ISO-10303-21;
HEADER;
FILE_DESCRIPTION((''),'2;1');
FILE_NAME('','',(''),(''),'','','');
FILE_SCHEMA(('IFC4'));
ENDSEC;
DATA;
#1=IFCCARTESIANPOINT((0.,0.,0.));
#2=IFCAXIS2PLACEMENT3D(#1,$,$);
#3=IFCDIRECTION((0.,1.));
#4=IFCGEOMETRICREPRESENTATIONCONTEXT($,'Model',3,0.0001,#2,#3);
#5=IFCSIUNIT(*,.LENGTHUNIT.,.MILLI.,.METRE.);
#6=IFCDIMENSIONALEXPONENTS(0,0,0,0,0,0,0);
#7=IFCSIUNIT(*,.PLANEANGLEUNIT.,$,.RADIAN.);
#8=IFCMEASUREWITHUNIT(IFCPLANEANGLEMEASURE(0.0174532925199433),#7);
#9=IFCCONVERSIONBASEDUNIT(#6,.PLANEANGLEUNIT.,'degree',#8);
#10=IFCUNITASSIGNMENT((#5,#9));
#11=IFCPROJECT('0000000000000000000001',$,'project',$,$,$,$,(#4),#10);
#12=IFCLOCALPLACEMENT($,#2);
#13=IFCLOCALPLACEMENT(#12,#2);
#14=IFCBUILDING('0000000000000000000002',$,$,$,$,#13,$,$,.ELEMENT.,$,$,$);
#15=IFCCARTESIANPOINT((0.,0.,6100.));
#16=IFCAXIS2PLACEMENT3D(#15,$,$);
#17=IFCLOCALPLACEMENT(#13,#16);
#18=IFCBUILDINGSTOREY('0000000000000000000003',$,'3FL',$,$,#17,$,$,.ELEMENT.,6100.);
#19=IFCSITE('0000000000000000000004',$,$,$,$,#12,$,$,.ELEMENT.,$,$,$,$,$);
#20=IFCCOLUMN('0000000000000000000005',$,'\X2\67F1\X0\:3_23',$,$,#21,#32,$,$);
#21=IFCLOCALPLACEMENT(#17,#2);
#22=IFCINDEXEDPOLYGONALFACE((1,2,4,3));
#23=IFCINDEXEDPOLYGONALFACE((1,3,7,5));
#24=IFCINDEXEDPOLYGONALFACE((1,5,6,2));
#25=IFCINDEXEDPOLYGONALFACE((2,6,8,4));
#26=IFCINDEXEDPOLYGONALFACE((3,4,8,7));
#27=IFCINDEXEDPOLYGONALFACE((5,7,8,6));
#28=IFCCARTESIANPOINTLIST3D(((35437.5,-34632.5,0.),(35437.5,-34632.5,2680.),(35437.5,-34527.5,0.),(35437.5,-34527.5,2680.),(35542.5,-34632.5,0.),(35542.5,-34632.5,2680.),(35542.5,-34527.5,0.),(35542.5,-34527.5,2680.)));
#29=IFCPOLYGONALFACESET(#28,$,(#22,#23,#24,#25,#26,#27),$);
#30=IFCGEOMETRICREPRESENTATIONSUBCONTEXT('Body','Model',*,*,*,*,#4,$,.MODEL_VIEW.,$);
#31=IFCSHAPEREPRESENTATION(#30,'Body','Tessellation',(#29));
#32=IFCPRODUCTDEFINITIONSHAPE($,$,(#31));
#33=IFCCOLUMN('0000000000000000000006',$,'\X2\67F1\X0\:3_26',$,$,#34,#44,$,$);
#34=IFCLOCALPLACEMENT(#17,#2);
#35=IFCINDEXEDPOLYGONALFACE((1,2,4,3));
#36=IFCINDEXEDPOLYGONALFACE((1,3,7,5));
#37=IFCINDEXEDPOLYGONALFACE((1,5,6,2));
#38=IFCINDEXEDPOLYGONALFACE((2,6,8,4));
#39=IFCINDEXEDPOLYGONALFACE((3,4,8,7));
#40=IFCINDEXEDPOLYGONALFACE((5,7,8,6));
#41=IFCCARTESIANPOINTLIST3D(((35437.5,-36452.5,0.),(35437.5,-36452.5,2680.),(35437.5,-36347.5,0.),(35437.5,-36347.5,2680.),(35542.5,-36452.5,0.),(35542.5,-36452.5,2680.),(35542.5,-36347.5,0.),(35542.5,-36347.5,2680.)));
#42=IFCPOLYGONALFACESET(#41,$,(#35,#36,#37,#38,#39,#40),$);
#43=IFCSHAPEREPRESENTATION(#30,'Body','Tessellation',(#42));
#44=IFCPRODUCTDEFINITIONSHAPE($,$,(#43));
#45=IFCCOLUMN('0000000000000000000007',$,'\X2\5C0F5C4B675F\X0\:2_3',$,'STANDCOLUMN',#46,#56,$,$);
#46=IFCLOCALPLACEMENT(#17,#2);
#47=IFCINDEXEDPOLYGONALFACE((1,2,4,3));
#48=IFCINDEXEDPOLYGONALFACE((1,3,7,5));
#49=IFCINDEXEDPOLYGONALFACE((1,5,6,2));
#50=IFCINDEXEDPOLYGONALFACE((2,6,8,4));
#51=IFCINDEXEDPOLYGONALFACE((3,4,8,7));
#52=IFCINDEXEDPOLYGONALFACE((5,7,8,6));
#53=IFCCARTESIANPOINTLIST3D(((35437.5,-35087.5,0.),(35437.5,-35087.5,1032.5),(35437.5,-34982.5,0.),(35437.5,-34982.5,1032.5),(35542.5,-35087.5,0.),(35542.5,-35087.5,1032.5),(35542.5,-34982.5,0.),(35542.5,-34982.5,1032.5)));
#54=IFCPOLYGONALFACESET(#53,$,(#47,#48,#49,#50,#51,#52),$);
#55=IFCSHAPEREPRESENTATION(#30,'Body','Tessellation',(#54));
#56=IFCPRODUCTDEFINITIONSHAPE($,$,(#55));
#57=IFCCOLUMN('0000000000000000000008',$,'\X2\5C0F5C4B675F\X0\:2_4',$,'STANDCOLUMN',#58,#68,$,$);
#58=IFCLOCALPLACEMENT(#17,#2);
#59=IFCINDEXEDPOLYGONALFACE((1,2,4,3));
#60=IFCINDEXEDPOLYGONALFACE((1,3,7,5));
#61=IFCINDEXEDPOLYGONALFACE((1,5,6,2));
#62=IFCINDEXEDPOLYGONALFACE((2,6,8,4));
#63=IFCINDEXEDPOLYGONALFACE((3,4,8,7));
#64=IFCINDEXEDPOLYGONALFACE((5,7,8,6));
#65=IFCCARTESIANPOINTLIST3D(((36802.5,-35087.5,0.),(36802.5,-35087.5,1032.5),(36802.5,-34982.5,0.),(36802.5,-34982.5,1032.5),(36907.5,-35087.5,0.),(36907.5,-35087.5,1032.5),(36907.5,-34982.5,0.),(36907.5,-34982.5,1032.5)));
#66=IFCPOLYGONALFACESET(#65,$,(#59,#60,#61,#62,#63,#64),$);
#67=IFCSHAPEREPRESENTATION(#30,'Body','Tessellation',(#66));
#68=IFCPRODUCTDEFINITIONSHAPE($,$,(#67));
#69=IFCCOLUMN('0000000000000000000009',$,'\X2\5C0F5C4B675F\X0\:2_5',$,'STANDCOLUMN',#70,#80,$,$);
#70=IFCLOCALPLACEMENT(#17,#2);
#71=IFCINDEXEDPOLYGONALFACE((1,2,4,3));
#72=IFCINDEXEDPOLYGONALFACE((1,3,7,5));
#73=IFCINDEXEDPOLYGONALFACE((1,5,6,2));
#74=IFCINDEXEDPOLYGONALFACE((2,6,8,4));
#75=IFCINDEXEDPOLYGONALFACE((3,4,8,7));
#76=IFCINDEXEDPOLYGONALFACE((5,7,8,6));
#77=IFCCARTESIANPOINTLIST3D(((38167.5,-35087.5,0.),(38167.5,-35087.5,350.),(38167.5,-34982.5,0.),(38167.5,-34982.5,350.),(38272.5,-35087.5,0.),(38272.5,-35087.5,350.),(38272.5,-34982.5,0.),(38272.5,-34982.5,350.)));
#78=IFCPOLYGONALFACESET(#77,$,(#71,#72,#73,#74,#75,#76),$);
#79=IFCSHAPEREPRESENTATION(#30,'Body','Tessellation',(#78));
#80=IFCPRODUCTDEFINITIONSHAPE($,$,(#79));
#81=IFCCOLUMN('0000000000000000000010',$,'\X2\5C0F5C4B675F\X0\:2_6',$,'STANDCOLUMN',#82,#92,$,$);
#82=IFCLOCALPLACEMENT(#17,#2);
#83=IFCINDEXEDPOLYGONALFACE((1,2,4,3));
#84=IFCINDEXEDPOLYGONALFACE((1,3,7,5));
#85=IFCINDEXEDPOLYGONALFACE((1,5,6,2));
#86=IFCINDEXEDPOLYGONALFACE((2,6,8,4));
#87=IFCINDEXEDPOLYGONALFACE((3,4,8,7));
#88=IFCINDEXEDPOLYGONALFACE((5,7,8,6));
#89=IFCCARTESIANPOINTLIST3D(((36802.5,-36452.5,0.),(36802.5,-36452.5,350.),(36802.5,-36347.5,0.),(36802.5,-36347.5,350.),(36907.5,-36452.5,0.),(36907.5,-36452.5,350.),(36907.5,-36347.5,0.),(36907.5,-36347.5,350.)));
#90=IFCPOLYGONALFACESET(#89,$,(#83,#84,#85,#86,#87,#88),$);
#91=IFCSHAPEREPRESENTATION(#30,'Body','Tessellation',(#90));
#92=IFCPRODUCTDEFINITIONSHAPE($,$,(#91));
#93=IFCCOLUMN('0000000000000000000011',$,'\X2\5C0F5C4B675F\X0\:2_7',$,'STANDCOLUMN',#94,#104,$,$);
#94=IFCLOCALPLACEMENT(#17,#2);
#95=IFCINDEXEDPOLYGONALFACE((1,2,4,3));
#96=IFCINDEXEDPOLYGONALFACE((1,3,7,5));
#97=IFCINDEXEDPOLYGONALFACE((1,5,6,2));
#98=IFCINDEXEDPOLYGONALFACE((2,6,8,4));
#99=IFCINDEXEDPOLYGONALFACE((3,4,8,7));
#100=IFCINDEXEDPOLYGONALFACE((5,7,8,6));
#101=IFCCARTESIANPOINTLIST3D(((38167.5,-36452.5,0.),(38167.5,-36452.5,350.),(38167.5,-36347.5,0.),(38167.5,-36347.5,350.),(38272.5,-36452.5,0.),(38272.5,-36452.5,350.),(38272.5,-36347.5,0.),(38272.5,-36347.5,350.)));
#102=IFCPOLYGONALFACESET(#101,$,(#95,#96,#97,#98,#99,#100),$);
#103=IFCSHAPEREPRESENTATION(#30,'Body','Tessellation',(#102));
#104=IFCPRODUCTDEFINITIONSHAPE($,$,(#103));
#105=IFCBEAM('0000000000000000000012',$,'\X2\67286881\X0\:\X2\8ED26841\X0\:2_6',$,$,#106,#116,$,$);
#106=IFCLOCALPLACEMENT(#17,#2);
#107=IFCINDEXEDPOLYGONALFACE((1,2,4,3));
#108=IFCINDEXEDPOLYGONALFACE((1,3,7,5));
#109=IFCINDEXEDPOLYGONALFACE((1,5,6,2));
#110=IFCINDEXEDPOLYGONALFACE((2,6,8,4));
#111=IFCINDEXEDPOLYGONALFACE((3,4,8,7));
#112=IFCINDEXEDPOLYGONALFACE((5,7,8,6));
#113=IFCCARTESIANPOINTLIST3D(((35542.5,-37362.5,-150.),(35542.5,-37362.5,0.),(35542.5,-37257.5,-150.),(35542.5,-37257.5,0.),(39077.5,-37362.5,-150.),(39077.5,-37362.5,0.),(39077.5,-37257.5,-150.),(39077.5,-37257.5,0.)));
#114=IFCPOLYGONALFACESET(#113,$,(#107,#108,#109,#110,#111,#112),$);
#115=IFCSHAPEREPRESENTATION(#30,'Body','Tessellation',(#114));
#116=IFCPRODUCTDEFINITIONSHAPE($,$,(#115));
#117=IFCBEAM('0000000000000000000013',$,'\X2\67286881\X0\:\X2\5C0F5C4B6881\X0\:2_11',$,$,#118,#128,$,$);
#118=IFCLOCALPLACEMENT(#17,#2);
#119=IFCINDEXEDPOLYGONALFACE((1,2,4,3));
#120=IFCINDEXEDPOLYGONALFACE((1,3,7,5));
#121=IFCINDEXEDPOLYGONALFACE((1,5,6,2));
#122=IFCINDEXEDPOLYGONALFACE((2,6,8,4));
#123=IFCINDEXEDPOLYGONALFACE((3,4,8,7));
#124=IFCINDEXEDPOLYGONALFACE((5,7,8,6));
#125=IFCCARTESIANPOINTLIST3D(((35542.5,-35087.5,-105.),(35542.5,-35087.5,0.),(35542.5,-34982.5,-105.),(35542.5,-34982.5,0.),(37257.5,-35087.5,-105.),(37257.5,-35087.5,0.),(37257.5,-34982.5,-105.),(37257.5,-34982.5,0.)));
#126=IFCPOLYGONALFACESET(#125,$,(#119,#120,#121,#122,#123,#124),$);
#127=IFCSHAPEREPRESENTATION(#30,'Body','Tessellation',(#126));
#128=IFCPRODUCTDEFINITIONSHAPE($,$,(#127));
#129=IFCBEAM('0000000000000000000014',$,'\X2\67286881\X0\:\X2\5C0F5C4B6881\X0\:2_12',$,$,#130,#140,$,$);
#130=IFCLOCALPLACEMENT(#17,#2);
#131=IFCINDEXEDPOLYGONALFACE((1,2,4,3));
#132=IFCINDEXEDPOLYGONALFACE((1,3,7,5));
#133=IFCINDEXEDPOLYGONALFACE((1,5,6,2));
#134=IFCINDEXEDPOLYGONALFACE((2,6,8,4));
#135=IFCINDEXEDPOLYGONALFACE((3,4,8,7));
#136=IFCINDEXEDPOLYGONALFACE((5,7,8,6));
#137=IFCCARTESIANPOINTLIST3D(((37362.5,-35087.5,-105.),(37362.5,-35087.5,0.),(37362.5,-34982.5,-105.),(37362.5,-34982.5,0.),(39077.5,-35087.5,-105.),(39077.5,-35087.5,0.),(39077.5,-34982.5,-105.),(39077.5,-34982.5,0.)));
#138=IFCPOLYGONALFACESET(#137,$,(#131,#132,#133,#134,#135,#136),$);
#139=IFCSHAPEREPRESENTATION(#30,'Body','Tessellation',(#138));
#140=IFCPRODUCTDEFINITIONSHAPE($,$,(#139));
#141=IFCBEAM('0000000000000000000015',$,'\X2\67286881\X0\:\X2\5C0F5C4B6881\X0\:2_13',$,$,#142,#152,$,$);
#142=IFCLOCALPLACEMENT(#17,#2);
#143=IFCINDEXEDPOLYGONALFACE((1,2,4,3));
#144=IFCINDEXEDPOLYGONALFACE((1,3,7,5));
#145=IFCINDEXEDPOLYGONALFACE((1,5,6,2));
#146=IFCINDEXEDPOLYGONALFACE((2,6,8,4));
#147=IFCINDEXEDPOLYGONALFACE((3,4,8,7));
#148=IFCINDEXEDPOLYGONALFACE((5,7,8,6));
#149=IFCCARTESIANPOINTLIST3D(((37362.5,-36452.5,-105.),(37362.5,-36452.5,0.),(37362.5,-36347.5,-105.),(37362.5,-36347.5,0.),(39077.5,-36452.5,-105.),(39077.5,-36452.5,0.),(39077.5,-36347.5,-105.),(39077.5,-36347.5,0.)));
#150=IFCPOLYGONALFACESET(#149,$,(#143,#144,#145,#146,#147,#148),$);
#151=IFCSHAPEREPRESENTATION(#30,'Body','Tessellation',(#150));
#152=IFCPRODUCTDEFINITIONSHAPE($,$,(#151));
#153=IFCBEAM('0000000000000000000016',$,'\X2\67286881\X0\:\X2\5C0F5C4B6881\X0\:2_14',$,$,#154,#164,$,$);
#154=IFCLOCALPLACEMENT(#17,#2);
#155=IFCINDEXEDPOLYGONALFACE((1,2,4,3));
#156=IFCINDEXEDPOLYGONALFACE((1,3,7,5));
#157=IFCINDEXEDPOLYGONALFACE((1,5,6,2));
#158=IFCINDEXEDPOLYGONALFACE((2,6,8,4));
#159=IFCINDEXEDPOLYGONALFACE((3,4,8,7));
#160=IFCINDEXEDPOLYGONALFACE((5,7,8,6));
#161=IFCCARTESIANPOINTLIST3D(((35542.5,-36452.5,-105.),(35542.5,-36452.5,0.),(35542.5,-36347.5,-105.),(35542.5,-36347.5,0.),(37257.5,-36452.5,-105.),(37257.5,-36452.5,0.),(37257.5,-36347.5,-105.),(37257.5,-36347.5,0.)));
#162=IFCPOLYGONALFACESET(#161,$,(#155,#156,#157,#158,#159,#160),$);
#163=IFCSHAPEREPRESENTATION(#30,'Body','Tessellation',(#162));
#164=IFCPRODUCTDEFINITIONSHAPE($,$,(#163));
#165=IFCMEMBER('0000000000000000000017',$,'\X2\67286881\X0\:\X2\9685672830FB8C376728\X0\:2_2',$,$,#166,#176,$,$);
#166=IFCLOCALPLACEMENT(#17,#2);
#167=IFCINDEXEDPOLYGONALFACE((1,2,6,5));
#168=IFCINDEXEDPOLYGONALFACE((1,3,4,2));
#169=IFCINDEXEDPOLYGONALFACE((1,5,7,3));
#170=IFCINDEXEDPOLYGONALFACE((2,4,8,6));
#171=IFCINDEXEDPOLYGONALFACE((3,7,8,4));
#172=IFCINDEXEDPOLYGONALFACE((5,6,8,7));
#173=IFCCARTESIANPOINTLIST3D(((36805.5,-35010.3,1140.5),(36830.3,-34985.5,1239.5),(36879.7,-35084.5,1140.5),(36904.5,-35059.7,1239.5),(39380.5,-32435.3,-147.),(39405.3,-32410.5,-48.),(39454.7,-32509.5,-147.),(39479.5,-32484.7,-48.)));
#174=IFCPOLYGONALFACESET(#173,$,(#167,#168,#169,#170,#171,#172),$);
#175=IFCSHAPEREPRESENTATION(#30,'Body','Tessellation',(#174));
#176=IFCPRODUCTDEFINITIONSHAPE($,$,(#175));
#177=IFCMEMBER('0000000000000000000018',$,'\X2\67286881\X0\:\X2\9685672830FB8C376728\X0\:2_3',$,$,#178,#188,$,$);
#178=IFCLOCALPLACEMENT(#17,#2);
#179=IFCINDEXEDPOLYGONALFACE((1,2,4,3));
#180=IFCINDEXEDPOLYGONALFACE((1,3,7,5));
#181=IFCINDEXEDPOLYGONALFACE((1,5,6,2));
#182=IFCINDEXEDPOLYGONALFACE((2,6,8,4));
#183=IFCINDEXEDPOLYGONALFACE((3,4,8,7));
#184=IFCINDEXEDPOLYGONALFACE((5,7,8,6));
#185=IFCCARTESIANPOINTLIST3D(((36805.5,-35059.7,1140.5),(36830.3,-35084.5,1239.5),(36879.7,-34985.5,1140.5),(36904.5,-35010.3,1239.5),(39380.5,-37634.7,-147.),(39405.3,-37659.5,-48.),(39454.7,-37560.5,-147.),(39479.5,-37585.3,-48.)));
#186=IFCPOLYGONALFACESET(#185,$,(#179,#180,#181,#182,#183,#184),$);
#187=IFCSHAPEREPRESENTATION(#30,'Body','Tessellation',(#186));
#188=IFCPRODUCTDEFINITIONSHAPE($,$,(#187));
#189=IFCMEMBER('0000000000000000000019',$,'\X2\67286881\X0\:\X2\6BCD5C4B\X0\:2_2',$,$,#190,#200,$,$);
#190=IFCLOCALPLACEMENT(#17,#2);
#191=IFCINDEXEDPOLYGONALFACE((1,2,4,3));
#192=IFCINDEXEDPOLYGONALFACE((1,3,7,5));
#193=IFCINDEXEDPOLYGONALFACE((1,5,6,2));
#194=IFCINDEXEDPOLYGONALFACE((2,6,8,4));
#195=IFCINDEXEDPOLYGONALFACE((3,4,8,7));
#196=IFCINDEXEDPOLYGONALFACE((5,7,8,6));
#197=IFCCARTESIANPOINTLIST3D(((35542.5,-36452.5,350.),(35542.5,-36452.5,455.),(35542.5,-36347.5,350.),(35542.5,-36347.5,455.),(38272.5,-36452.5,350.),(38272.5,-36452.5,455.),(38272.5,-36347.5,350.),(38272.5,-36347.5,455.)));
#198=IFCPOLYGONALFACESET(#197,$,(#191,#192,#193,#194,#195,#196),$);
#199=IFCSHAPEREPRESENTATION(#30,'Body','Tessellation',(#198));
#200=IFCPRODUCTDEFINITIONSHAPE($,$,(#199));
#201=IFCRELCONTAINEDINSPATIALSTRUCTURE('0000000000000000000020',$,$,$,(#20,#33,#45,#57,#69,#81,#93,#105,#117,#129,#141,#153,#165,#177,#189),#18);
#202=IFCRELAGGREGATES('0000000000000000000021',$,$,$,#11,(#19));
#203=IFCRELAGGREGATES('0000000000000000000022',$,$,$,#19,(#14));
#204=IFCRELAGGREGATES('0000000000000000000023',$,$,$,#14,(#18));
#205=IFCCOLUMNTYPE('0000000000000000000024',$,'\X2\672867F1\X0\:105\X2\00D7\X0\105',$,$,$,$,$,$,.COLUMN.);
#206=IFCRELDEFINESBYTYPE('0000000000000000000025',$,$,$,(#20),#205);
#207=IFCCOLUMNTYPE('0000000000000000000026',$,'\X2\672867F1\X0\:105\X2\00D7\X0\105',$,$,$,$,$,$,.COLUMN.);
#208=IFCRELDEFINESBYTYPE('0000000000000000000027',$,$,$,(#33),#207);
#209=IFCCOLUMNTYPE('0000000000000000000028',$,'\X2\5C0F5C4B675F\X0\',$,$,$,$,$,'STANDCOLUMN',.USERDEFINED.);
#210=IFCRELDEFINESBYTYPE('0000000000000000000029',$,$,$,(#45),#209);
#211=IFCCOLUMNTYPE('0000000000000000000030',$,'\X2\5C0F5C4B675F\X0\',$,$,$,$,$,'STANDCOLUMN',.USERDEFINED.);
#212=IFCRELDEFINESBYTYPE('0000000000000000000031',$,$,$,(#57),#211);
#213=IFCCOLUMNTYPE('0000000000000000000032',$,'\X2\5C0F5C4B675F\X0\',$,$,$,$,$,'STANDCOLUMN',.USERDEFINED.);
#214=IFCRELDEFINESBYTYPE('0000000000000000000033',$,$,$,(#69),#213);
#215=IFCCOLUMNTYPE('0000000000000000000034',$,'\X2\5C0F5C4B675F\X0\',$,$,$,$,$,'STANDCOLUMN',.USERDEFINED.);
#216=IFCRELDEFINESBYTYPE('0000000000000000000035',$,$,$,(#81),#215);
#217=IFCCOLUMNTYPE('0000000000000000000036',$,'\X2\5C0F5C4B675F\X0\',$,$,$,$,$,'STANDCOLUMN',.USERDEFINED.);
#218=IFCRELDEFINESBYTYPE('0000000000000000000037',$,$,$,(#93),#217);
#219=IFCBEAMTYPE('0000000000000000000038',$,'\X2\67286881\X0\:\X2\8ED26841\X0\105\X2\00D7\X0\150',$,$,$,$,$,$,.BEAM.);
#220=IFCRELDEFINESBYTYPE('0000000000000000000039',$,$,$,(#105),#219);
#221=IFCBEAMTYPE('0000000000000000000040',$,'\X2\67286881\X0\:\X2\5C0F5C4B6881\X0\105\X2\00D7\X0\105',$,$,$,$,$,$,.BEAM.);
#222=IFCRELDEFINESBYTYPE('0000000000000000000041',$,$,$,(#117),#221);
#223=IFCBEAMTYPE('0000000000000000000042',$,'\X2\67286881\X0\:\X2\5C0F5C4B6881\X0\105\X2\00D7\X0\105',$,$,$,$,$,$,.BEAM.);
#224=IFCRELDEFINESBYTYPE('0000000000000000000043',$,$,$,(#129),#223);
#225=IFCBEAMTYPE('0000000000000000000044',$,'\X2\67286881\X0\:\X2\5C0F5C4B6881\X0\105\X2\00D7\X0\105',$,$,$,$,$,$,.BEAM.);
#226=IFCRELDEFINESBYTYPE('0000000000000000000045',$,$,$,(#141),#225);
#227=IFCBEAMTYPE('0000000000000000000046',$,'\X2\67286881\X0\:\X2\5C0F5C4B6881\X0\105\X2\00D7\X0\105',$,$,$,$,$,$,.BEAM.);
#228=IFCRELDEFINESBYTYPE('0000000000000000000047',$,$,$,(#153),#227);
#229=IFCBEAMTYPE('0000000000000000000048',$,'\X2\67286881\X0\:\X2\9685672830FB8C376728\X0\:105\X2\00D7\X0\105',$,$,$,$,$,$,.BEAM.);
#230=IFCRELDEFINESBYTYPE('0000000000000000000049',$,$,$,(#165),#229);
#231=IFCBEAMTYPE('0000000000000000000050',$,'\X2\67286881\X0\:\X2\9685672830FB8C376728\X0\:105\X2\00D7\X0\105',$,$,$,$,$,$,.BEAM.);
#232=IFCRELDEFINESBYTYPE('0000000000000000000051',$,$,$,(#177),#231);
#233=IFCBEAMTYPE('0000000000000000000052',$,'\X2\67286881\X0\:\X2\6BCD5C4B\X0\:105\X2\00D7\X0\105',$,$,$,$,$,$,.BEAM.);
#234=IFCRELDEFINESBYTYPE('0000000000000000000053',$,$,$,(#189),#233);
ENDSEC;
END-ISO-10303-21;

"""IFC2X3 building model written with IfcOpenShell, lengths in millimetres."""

from ifc_helpers import new_model, entity, si_unit, converted_unit, direction, frame, origin, origin_with_axes, origin_2d, place, context, subcontext, project, spatial, rectangle, extrude, type_object, element, save


model = new_model("IFC2X3")

# Units and contexts
model_context = context("Model", 3, precision=0.0001, world=origin(), true_north=direction((0.0, 1.0)))
body_context = subcontext(model_context, "Body", "Model", "MODEL_VIEW")
ifc_project = project(units=[si_unit("LENGTHUNIT", "METRE", prefix="MILLI"), converted_unit("PLANEANGLEUNIT", "degree", entity("IfcPlaneAngleMeasure", 0.0174532925199433), si_unit("PLANEANGLEUNIT", "RADIAN"), dimensions=[0, 0, 0, 0, 0, 0, 0])], contexts=[model_context])

# Site, building, storey
site_placement = place(None, origin())
site = spatial("IfcSite", under=ifc_project, at=site_placement, CompositionType="ELEMENT")
building_placement = place(site_placement, origin())
building = spatial("IfcBuilding", under=site, at=building_placement, CompositionType="ELEMENT")
storey_placement = place(building_placement, frame((0.0, 0.0, 6100.0)))
storey = spatial("IfcBuildingStorey", under=building, at=storey_placement, Name="3FL", CompositionType="ELEMENT", Elevation=6100.0)

# Columns
column_type_1 = type_object("IfcColumnType", Name="木柱:105×105", PredefinedType="COLUMN")
column_1_placement = place(storey_placement, frame((35490.0, -34580.0, 0.0)))
element("IfcColumn", 1, at=column_1_placement, inside=storey, type_object=column_type_1, Name="柱:3_23", context=body_context, shape_type="SweptSolid", body=[
    extrude(rectangle(XDim=105.0, YDim=105.0, at=origin_2d()), origin_with_axes(), (0.0, 0.0, 1.0), 2680.0),
])
column_type_2 = type_object("IfcColumnType", Name="木柱:105×105", PredefinedType="COLUMN")
column_2_placement = place(storey_placement, frame((35490.0, -36400.0, 0.0)))
element("IfcColumn", 2, at=column_2_placement, inside=storey, type_object=column_type_2, Name="柱:3_26", context=body_context, shape_type="SweptSolid", body=[
    extrude(rectangle(XDim=105.0, YDim=105.0, at=origin_2d()), origin_with_axes(), (0.0, 0.0, 1.0), 2680.0),
])
column_type_3 = type_object("IfcColumnType", Name="小屋束", ElementType="STANDCOLUMN", PredefinedType="USERDEFINED")
column_3_placement = place(storey_placement, frame((35490.0, -35035.0, 0.0)))
element("IfcColumn", 3, at=column_3_placement, inside=storey, type_object=column_type_3, Name="小屋束:2_3", ObjectType="STANDCOLUMN", context=body_context, shape_type="SweptSolid", body=[
    extrude(rectangle(XDim=105.0, YDim=105.0, at=origin_2d()), origin_with_axes(), (0.0, 0.0, 1.0), 1032.5),
])
column_type_4 = type_object("IfcColumnType", Name="小屋束", ElementType="STANDCOLUMN", PredefinedType="USERDEFINED")
column_4_placement = place(storey_placement, frame((36855.0, -35035.0, 0.0)))
element("IfcColumn", 4, at=column_4_placement, inside=storey, type_object=column_type_4, Name="小屋束:2_4", ObjectType="STANDCOLUMN", context=body_context, shape_type="SweptSolid", body=[
    extrude(rectangle(XDim=105.0, YDim=105.0, at=origin_2d()), origin_with_axes(), (0.0, 0.0, 1.0), 1032.5),
])
column_type_5 = type_object("IfcColumnType", Name="小屋束", ElementType="STANDCOLUMN", PredefinedType="USERDEFINED")
column_5_placement = place(storey_placement, frame((38220.0, -35035.0, 0.0)))
element("IfcColumn", 5, at=column_5_placement, inside=storey, type_object=column_type_5, Name="小屋束:2_5", ObjectType="STANDCOLUMN", context=body_context, shape_type="SweptSolid", body=[
    extrude(rectangle(XDim=105.0, YDim=105.0, at=origin_2d()), origin_with_axes(), (0.0, 0.0, 1.0), 350.0),
])
column_type_6 = type_object("IfcColumnType", Name="小屋束", ElementType="STANDCOLUMN", PredefinedType="USERDEFINED")
column_6_placement = place(storey_placement, frame((36855.0, -36400.0, 0.0)))
element("IfcColumn", 6, at=column_6_placement, inside=storey, type_object=column_type_6, Name="小屋束:2_6", ObjectType="STANDCOLUMN", context=body_context, shape_type="SweptSolid", body=[
    extrude(rectangle(XDim=105.0, YDim=105.0, at=origin_2d()), origin_with_axes(), (0.0, 0.0, 1.0), 350.0),
])
column_type_7 = type_object("IfcColumnType", Name="小屋束", ElementType="STANDCOLUMN", PredefinedType="USERDEFINED")
column_7_placement = place(storey_placement, frame((38220.0, -36400.0, 0.0)))
element("IfcColumn", 7, at=column_7_placement, inside=storey, type_object=column_type_7, Name="小屋束:2_7", ObjectType="STANDCOLUMN", context=body_context, shape_type="SweptSolid", body=[
    extrude(rectangle(XDim=105.0, YDim=105.0, at=origin_2d()), origin_with_axes(), (0.0, 0.0, 1.0), 350.0),
])

# Beams
beam_type_1 = type_object("IfcBeamType", Name="木梁:軒桁105×150", PredefinedType="BEAM")
beam_1_placement = place(storey_placement, frame((35542.5, -37310.0, -75.0), z_axis=(1.0, 0.0, 0.0), x_axis=(0.0, 1.0, 0.0)))
element("IfcBeam", 8, at=beam_1_placement, inside=storey, type_object=beam_type_1, Name="木梁:軒桁:2_6", context=body_context, shape_type="SweptSolid", body=[
    extrude(rectangle(XDim=105.0, YDim=150.0, at=origin_2d()), origin_with_axes(), (0.0, 0.0, 1.0), 3535.0),
])
beam_type_2 = type_object("IfcBeamType", Name="木梁:小屋梁105×105", PredefinedType="BEAM")
beam_2_placement = place(storey_placement, frame((35542.5, -35035.0, -52.5), z_axis=(1.0, 0.0, 0.0), x_axis=(0.0, 1.0, 0.0)))
element("IfcBeam", 9, at=beam_2_placement, inside=storey, type_object=beam_type_2, Name="木梁:小屋梁:2_11", context=body_context, shape_type="SweptSolid", body=[
    extrude(rectangle(XDim=105.0, YDim=105.0, at=origin_2d()), origin_with_axes(), (0.0, 0.0, 1.0), 1715.0),
])
beam_type_3 = type_object("IfcBeamType", Name="木梁:小屋梁105×105", PredefinedType="BEAM")
beam_3_placement = place(storey_placement, frame((37362.5, -35035.0, -52.5), z_axis=(1.0, 0.0, 0.0), x_axis=(0.0, 1.0, 0.0)))
element("IfcBeam", 10, at=beam_3_placement, inside=storey, type_object=beam_type_3, Name="木梁:小屋梁:2_12", context=body_context, shape_type="SweptSolid", body=[
    extrude(rectangle(XDim=105.0, YDim=105.0, at=origin_2d()), origin_with_axes(), (0.0, 0.0, 1.0), 1715.0),
])
beam_type_4 = type_object("IfcBeamType", Name="木梁:小屋梁105×105", PredefinedType="BEAM")
beam_4_placement = place(storey_placement, frame((37362.5, -36400.0, -52.5), z_axis=(1.0, 0.0, 0.0), x_axis=(0.0, 1.0, 0.0)))
element("IfcBeam", 11, at=beam_4_placement, inside=storey, type_object=beam_type_4, Name="木梁:小屋梁:2_13", context=body_context, shape_type="SweptSolid", body=[
    extrude(rectangle(XDim=105.0, YDim=105.0, at=origin_2d()), origin_with_axes(), (0.0, 0.0, 1.0), 1715.0),
])
beam_type_5 = type_object("IfcBeamType", Name="木梁:小屋梁105×105", PredefinedType="BEAM")
beam_5_placement = place(storey_placement, frame((35542.5, -36400.0, -52.5), z_axis=(1.0, 0.0, 0.0), x_axis=(0.0, 1.0, 0.0)))
element("IfcBeam", 12, at=beam_5_placement, inside=storey, type_object=beam_type_5, Name="木梁:小屋梁:2_14", context=body_context, shape_type="SweptSolid", body=[
    extrude(rectangle(XDim=105.0, YDim=105.0, at=origin_2d()), origin_with_axes(), (0.0, 0.0, 1.0), 1715.0),
])

# Members
beam_type_6 = type_object("IfcBeamType", Name="木梁:隅木・谷木:105×105", PredefinedType="BEAM")
member_1_placement = place(storey_placement, frame((36855.0, -35035.0, 1190.0), z_axis=(0.666667, 0.666667, -0.333333), x_axis=(0.707107, -0.707107, 0.0)))
element("IfcMember", 13, at=member_1_placement, inside=storey, type_object=beam_type_6, Name="木梁:隅木・谷木:2_2", context=body_context, shape_type="SweptSolid", body=[
    extrude(rectangle(XDim=105.0, YDim=105.0, at=origin_2d()), origin_with_axes(), (0.0, 0.0, 1.0), 3862.5),
])
beam_type_7 = type_object("IfcBeamType", Name="木梁:隅木・谷木:105×105", PredefinedType="BEAM")
member_2_placement = place(storey_placement, frame((36855.0, -35035.0, 1190.0), z_axis=(0.666667, -0.666667, -0.333333), x_axis=(-0.707107, -0.707107, 0.0)))
element("IfcMember", 14, at=member_2_placement, inside=storey, type_object=beam_type_7, Name="木梁:隅木・谷木:2_3", context=body_context, shape_type="SweptSolid", body=[
    extrude(rectangle(XDim=105.0, YDim=105.0, at=origin_2d()), origin_with_axes(), (0.0, 0.0, 1.0), 3862.5),
])
beam_type_8 = type_object("IfcBeamType", Name="木梁:母屋:105×105", PredefinedType="BEAM")
member_3_placement = place(storey_placement, frame((35542.5, -36400.0, 402.5), z_axis=(1.0, 0.0, 0.0), x_axis=(0.0, -1.0, 0.0)))
element("IfcMember", 15, at=member_3_placement, inside=storey, type_object=beam_type_8, Name="木梁:母屋:2_2", context=body_context, shape_type="SweptSolid", body=[
    extrude(rectangle(XDim=105.0, YDim=105.0, at=origin_2d()), origin_with_axes(), (0.0, 0.0, 1.0), 2730.0),
])

save(model, "model.ifc")
